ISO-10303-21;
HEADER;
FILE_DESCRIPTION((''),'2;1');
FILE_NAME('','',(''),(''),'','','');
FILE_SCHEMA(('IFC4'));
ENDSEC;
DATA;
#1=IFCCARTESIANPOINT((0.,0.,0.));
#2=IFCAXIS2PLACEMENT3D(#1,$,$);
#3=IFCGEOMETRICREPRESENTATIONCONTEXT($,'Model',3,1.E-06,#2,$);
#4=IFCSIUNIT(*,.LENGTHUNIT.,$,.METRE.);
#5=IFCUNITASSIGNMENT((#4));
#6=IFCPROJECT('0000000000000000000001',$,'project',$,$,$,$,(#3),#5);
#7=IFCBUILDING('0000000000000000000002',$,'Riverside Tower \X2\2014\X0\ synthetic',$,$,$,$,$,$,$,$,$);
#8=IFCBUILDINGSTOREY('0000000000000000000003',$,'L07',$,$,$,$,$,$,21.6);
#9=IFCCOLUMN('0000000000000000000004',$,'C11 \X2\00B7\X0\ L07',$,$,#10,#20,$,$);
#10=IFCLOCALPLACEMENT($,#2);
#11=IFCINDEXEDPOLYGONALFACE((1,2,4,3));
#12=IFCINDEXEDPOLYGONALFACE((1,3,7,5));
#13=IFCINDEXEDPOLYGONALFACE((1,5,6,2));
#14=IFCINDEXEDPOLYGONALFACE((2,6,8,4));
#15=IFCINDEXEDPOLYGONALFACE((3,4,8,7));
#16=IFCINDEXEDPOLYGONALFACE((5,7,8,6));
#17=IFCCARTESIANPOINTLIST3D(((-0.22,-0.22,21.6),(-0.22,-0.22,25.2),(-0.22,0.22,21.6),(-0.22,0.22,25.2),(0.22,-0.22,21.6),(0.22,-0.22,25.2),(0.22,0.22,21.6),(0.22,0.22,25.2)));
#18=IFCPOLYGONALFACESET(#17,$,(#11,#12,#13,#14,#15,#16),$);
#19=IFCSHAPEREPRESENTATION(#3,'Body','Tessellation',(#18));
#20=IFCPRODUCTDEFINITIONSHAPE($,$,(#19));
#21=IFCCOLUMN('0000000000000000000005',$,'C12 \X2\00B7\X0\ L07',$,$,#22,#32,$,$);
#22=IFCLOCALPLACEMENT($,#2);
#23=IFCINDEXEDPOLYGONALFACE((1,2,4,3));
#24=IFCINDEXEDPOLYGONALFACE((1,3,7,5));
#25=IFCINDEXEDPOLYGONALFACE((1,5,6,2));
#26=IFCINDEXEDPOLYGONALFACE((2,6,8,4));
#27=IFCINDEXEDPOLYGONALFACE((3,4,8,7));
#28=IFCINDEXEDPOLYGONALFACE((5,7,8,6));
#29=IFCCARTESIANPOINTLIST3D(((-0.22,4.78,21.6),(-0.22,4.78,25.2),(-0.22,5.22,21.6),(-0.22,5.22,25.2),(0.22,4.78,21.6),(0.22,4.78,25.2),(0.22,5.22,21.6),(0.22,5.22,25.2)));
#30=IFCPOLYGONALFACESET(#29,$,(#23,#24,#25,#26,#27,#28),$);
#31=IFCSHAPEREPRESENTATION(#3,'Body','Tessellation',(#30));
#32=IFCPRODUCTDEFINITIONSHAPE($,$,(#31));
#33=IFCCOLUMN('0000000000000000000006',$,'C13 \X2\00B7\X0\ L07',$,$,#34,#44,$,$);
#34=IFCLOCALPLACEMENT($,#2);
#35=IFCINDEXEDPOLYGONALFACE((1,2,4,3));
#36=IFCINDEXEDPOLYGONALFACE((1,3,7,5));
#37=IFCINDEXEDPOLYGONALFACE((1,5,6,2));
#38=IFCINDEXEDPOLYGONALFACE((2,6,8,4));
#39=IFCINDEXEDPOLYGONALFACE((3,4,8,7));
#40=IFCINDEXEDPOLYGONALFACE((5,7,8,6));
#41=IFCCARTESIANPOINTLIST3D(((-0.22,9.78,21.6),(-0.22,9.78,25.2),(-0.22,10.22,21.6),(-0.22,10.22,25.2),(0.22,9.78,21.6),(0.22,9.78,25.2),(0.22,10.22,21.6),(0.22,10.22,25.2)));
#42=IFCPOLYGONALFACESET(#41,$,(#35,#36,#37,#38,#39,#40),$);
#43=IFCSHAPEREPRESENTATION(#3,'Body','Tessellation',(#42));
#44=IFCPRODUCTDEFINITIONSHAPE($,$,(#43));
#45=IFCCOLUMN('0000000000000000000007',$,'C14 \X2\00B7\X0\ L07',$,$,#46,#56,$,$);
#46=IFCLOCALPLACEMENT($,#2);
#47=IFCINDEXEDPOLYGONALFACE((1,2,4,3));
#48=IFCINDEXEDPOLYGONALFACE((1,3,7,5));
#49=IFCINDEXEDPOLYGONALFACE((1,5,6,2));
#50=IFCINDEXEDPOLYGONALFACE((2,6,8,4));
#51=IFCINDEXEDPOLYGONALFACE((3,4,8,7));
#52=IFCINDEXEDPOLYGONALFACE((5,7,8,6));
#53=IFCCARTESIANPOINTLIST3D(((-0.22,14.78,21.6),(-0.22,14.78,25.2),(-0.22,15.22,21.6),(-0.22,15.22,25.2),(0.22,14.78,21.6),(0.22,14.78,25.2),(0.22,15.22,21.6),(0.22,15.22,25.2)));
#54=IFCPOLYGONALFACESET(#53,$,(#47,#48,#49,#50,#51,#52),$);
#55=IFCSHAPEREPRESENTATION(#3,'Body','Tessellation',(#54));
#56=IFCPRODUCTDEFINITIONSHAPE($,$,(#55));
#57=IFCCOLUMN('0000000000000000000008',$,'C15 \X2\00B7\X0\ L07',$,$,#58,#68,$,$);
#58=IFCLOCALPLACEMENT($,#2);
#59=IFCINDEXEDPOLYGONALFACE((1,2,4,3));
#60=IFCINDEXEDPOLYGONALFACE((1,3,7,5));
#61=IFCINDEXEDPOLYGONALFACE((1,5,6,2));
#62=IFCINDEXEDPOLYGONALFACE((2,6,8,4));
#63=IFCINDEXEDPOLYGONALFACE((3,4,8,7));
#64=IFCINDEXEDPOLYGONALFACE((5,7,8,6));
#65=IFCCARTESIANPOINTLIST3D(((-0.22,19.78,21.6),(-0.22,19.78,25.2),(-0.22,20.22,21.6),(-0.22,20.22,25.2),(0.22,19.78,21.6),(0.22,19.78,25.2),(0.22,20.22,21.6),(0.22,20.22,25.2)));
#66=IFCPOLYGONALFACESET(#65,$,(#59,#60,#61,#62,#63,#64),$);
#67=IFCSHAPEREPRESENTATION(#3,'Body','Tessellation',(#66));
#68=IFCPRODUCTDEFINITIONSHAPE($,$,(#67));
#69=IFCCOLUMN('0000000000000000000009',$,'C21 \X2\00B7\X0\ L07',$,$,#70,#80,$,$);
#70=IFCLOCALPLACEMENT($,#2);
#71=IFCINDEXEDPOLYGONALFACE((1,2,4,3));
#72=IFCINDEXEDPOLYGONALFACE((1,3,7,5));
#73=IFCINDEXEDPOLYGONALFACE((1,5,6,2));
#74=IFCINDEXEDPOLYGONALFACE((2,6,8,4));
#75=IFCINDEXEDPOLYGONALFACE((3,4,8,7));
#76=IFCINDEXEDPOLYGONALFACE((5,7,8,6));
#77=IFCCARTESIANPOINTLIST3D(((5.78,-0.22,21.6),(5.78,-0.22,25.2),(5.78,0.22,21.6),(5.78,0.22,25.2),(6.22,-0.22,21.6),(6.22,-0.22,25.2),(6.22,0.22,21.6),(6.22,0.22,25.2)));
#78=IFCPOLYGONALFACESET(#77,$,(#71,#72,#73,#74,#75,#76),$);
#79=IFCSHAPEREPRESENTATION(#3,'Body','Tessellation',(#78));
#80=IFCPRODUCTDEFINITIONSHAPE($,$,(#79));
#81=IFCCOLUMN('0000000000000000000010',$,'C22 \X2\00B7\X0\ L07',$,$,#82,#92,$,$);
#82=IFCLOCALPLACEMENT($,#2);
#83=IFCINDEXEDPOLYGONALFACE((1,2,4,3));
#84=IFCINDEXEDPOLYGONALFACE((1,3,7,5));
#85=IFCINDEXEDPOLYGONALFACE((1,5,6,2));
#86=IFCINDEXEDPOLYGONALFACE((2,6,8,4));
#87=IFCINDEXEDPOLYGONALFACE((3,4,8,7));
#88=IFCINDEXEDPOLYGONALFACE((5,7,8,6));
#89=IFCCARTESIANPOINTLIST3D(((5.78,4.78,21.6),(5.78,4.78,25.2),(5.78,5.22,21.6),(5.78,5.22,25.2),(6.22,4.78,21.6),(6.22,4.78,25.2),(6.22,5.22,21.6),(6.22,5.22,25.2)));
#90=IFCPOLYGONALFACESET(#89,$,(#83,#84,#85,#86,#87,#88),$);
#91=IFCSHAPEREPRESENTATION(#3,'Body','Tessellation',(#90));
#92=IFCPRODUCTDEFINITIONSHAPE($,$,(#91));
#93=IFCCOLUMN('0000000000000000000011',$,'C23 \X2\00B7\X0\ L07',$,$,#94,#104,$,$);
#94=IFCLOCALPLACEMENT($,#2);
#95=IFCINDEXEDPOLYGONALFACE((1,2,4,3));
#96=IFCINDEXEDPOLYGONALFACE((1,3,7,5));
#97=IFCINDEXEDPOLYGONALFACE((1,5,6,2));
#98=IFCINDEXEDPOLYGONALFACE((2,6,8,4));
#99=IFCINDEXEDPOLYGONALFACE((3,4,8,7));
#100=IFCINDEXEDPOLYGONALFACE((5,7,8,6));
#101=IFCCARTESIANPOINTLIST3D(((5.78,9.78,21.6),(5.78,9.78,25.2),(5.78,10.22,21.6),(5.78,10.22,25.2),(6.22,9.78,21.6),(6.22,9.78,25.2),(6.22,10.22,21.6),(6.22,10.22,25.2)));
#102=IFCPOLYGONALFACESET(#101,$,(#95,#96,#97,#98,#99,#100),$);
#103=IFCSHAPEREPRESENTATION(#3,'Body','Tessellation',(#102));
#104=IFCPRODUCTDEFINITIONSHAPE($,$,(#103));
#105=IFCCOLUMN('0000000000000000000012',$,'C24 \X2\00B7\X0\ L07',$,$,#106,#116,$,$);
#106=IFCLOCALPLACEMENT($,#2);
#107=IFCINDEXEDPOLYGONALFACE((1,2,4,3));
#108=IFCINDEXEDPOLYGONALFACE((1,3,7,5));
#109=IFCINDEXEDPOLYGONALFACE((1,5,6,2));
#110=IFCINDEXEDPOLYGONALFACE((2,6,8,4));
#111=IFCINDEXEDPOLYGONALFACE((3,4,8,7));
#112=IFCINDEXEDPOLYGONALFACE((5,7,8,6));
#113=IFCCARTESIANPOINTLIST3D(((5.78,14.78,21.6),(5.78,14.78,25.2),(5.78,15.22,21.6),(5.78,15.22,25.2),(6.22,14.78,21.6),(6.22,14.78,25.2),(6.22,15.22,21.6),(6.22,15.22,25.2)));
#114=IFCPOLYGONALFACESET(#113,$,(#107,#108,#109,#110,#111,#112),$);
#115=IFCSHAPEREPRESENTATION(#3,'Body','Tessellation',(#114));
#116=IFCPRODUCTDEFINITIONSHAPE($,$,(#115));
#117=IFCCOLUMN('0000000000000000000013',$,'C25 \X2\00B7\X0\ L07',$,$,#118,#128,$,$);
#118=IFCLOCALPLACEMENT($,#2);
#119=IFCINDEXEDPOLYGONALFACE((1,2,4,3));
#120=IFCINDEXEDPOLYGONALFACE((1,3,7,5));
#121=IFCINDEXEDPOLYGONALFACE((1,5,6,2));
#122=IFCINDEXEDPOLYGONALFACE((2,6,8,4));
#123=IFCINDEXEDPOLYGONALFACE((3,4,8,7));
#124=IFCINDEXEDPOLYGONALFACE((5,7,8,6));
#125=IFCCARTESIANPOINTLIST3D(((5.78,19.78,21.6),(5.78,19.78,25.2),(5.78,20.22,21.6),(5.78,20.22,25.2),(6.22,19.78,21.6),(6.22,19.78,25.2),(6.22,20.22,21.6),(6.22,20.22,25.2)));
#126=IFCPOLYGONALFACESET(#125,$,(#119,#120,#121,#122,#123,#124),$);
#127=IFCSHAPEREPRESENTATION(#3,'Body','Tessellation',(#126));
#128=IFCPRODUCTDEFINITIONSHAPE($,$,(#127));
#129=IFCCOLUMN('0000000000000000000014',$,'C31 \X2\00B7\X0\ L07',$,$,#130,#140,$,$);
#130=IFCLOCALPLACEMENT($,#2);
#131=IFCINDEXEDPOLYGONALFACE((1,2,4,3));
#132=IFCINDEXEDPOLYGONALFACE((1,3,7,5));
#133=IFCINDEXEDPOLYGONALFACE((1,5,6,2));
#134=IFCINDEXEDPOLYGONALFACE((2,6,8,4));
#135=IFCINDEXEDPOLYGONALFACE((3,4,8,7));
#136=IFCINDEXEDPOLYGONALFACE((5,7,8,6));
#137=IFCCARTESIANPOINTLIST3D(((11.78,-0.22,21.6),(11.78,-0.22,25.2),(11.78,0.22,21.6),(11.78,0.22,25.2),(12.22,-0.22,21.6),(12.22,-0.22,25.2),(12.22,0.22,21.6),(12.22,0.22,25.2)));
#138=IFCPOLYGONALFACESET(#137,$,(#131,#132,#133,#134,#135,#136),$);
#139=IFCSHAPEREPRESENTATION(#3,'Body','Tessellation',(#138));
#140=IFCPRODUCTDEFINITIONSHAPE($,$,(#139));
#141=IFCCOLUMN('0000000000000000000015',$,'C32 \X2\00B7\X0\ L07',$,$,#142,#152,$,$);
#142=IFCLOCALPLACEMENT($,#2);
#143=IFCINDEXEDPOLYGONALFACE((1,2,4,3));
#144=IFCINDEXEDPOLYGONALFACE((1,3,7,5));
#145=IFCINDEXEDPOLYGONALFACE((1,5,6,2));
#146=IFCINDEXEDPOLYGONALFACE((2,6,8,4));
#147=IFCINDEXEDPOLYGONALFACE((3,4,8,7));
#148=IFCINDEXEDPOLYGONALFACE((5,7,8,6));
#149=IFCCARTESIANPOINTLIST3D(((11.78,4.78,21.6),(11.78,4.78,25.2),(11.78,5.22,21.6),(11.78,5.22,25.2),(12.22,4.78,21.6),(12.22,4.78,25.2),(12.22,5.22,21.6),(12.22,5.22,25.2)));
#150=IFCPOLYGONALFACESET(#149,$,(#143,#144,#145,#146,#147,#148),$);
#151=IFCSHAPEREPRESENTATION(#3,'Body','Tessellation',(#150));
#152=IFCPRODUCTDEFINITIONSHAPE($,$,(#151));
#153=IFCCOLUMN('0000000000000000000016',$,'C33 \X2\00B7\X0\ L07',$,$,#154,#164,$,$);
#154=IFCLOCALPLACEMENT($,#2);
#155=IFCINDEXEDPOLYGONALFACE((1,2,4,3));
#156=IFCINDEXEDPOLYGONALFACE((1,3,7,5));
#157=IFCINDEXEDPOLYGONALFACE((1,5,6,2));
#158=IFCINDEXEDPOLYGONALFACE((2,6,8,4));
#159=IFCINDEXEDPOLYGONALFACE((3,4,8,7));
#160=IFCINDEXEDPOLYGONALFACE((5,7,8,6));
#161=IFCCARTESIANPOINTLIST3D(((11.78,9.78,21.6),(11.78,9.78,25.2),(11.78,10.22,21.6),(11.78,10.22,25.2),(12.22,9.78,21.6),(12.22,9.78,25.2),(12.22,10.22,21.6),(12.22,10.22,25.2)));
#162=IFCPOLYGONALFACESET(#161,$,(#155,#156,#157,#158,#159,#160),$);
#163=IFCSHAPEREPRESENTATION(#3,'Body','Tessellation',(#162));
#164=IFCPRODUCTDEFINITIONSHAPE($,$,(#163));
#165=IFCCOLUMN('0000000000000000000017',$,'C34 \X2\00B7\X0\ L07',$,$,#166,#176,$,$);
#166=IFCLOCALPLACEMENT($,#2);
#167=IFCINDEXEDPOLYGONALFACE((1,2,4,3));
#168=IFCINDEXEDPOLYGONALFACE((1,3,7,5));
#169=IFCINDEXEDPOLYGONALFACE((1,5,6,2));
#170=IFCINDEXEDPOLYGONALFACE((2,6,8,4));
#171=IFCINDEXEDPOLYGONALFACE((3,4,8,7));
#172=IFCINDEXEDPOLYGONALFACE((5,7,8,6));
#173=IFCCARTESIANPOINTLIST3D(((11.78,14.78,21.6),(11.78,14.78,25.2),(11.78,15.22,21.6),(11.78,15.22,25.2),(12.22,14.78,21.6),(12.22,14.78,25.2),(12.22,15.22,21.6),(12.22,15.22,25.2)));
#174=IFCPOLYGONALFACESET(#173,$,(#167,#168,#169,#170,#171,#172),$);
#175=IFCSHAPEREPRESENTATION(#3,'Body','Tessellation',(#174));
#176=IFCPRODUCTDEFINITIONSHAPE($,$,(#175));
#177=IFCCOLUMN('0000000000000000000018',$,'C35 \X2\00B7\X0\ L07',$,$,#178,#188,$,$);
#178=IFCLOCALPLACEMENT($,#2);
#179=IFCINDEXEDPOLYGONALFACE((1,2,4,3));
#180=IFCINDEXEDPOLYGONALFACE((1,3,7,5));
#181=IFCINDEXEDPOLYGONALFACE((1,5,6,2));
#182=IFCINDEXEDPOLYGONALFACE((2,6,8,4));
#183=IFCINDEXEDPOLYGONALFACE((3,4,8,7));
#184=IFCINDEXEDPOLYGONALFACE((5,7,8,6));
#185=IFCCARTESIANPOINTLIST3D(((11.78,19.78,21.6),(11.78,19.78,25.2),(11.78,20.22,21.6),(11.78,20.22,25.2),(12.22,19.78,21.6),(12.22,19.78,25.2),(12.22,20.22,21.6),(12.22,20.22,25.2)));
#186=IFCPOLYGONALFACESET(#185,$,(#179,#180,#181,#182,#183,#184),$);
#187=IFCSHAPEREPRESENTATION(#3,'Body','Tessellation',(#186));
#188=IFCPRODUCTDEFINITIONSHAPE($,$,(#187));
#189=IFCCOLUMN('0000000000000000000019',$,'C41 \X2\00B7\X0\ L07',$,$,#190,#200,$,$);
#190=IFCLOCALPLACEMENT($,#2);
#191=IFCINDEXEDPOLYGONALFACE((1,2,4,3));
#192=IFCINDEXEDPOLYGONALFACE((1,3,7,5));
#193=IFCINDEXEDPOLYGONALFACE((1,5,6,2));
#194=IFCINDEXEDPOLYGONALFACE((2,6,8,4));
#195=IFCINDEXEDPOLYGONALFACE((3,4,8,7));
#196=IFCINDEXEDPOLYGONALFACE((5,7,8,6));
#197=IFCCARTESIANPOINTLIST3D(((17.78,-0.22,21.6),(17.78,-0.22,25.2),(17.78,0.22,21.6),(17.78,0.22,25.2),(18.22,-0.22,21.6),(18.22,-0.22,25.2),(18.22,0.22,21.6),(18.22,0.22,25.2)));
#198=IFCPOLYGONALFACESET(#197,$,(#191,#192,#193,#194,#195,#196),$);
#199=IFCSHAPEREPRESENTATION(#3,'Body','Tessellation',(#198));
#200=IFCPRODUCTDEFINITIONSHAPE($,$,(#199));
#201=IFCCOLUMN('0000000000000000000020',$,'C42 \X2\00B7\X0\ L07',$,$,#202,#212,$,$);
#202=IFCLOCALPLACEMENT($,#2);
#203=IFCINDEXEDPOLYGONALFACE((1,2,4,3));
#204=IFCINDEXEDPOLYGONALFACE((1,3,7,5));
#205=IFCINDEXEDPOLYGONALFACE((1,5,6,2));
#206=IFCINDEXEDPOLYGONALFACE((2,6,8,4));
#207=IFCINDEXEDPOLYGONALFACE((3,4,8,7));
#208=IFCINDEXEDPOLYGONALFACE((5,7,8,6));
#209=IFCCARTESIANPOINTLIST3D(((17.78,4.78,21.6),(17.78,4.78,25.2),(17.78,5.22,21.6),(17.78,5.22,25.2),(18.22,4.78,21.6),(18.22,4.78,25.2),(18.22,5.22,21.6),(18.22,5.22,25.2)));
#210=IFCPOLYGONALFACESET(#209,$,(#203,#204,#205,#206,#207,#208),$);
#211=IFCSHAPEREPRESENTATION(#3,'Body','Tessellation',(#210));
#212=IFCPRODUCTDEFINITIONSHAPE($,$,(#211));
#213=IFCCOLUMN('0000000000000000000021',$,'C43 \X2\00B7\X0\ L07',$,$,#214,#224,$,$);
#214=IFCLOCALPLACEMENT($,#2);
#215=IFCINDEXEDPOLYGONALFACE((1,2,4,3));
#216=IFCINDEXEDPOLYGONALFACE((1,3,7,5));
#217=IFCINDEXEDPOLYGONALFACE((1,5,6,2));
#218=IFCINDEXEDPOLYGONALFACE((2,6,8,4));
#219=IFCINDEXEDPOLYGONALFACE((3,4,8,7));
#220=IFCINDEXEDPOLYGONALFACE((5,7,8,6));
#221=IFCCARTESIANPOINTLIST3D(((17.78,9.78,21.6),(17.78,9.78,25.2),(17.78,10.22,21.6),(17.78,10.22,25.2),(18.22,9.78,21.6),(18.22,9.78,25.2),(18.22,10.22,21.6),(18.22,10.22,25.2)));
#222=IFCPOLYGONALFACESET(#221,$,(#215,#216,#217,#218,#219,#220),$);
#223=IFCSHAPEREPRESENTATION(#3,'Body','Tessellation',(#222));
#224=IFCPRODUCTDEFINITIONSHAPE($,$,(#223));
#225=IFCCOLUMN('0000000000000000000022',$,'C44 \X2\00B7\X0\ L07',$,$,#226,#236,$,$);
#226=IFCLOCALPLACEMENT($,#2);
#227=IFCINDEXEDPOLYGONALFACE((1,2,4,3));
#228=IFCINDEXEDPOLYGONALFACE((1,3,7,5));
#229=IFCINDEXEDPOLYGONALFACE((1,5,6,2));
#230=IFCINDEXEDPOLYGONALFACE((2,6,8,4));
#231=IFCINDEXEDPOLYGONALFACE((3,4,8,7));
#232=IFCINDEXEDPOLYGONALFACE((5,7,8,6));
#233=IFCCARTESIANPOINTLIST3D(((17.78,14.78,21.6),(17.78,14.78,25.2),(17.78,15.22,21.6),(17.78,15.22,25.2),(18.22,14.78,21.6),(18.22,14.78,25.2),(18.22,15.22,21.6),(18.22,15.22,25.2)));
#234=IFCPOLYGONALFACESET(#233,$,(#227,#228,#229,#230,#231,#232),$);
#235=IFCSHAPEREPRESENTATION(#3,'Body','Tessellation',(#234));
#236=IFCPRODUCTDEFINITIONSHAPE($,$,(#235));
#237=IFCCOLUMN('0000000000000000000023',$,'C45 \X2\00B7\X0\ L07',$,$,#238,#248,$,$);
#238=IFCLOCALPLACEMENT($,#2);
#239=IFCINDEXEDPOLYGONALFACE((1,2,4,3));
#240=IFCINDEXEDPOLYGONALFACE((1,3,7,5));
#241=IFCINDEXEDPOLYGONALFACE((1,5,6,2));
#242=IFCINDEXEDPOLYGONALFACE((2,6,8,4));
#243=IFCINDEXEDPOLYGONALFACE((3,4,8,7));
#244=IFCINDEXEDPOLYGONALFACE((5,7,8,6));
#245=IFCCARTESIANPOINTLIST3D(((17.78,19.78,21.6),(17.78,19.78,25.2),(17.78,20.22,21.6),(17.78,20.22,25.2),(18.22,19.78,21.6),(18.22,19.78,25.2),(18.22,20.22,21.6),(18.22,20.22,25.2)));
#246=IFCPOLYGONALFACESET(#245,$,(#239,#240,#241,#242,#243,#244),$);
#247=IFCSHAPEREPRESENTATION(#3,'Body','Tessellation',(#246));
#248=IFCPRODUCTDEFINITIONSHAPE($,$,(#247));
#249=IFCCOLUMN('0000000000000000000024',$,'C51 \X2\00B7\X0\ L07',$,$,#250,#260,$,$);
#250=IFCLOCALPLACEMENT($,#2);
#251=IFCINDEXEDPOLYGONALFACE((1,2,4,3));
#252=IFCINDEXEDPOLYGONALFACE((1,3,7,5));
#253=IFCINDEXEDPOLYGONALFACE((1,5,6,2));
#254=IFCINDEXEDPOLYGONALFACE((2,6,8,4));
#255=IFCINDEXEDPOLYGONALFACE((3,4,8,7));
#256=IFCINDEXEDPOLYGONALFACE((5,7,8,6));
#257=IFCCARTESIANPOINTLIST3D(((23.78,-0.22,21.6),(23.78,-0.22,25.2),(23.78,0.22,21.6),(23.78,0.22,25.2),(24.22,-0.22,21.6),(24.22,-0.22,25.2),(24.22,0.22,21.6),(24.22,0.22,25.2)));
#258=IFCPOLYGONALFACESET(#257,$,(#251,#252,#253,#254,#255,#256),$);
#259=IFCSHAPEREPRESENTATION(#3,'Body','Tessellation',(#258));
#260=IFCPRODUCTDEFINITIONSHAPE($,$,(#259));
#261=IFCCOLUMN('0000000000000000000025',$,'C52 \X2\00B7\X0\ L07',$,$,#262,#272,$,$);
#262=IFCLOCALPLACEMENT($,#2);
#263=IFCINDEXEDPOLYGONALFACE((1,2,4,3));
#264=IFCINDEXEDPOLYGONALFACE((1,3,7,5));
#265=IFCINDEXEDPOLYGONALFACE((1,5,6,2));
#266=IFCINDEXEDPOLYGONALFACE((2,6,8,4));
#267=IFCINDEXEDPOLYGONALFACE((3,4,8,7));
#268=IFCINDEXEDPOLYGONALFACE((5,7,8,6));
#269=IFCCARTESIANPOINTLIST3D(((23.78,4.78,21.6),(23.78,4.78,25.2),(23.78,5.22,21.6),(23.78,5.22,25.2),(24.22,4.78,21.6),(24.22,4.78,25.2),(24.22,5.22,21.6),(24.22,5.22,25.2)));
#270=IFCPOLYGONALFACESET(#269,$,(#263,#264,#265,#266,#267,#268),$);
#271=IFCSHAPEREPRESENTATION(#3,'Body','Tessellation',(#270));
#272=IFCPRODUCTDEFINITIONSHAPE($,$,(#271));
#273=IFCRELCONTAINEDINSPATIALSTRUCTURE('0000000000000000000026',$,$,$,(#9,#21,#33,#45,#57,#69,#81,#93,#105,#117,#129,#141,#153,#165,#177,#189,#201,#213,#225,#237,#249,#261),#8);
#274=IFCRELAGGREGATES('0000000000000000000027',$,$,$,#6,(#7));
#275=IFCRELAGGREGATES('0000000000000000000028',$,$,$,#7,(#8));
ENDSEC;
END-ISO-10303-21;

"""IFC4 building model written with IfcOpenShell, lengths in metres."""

from ifc_helpers import new_model, si_unit, frame, origin, place, context, project, spatial, rectangle, extrude, element, save


model = new_model("IFC4")

# Units and contexts
model_context = context("Model", 3, precision=1e-06, world=origin())
ifc_project = project(units=[si_unit("LENGTHUNIT", "METRE")], contexts=[model_context])

# Building, storey
building = spatial("IfcBuilding", under=ifc_project, Name="Riverside Tower — synthetic")
storey = spatial("IfcBuildingStorey", under=building, Name="L07", Elevation=21.6)

# Columns
for number, where, name in (
    (1, (0.0, 0.0, 21.6), "C11 · L07"),
    (2, (0.0, 5.0, 21.6), "C12 · L07"),
    (3, (0.0, 10.0, 21.6), "C13 · L07"),
    (4, (0.0, 15.0, 21.6), "C14 · L07"),
    (5, (0.0, 20.0, 21.6), "C15 · L07"),
    (6, (6.0, 0.0, 21.6), "C21 · L07"),
    (7, (6.0, 5.0, 21.6), "C22 · L07"),
    (8, (6.0, 10.0, 21.6), "C23 · L07"),
    (9, (6.0, 15.0, 21.6), "C24 · L07"),
    (10, (6.0, 20.0, 21.6), "C25 · L07"),
    (11, (12.0, 0.0, 21.6), "C31 · L07"),
    (12, (12.0, 5.0, 21.6), "C32 · L07"),
    (13, (12.0, 10.0, 21.6), "C33 · L07"),
    (14, (12.0, 15.0, 21.6), "C34 · L07"),
    (15, (12.0, 20.0, 21.6), "C35 · L07"),
    (16, (18.0, 0.0, 21.6), "C41 · L07"),
    (17, (18.0, 5.0, 21.6), "C42 · L07"),
    (18, (18.0, 10.0, 21.6), "C43 · L07"),
    (19, (18.0, 15.0, 21.6), "C44 · L07"),
    (20, (18.0, 20.0, 21.6), "C45 · L07"),
    (21, (24.0, 0.0, 21.6), "C51 · L07"),
    (22, (24.0, 5.0, 21.6), "C52 · L07"),
):
    element("IfcColumn", number, at=place(None, frame(where)), inside=storey, Name=name, context=model_context, shape_type="SweptSolid", body=[
        extrude(rectangle(XDim=0.44, YDim=0.44), origin(), (0.0, 0.0, 1.0), 3.6),
    ])

save(model, "model.ifc")
